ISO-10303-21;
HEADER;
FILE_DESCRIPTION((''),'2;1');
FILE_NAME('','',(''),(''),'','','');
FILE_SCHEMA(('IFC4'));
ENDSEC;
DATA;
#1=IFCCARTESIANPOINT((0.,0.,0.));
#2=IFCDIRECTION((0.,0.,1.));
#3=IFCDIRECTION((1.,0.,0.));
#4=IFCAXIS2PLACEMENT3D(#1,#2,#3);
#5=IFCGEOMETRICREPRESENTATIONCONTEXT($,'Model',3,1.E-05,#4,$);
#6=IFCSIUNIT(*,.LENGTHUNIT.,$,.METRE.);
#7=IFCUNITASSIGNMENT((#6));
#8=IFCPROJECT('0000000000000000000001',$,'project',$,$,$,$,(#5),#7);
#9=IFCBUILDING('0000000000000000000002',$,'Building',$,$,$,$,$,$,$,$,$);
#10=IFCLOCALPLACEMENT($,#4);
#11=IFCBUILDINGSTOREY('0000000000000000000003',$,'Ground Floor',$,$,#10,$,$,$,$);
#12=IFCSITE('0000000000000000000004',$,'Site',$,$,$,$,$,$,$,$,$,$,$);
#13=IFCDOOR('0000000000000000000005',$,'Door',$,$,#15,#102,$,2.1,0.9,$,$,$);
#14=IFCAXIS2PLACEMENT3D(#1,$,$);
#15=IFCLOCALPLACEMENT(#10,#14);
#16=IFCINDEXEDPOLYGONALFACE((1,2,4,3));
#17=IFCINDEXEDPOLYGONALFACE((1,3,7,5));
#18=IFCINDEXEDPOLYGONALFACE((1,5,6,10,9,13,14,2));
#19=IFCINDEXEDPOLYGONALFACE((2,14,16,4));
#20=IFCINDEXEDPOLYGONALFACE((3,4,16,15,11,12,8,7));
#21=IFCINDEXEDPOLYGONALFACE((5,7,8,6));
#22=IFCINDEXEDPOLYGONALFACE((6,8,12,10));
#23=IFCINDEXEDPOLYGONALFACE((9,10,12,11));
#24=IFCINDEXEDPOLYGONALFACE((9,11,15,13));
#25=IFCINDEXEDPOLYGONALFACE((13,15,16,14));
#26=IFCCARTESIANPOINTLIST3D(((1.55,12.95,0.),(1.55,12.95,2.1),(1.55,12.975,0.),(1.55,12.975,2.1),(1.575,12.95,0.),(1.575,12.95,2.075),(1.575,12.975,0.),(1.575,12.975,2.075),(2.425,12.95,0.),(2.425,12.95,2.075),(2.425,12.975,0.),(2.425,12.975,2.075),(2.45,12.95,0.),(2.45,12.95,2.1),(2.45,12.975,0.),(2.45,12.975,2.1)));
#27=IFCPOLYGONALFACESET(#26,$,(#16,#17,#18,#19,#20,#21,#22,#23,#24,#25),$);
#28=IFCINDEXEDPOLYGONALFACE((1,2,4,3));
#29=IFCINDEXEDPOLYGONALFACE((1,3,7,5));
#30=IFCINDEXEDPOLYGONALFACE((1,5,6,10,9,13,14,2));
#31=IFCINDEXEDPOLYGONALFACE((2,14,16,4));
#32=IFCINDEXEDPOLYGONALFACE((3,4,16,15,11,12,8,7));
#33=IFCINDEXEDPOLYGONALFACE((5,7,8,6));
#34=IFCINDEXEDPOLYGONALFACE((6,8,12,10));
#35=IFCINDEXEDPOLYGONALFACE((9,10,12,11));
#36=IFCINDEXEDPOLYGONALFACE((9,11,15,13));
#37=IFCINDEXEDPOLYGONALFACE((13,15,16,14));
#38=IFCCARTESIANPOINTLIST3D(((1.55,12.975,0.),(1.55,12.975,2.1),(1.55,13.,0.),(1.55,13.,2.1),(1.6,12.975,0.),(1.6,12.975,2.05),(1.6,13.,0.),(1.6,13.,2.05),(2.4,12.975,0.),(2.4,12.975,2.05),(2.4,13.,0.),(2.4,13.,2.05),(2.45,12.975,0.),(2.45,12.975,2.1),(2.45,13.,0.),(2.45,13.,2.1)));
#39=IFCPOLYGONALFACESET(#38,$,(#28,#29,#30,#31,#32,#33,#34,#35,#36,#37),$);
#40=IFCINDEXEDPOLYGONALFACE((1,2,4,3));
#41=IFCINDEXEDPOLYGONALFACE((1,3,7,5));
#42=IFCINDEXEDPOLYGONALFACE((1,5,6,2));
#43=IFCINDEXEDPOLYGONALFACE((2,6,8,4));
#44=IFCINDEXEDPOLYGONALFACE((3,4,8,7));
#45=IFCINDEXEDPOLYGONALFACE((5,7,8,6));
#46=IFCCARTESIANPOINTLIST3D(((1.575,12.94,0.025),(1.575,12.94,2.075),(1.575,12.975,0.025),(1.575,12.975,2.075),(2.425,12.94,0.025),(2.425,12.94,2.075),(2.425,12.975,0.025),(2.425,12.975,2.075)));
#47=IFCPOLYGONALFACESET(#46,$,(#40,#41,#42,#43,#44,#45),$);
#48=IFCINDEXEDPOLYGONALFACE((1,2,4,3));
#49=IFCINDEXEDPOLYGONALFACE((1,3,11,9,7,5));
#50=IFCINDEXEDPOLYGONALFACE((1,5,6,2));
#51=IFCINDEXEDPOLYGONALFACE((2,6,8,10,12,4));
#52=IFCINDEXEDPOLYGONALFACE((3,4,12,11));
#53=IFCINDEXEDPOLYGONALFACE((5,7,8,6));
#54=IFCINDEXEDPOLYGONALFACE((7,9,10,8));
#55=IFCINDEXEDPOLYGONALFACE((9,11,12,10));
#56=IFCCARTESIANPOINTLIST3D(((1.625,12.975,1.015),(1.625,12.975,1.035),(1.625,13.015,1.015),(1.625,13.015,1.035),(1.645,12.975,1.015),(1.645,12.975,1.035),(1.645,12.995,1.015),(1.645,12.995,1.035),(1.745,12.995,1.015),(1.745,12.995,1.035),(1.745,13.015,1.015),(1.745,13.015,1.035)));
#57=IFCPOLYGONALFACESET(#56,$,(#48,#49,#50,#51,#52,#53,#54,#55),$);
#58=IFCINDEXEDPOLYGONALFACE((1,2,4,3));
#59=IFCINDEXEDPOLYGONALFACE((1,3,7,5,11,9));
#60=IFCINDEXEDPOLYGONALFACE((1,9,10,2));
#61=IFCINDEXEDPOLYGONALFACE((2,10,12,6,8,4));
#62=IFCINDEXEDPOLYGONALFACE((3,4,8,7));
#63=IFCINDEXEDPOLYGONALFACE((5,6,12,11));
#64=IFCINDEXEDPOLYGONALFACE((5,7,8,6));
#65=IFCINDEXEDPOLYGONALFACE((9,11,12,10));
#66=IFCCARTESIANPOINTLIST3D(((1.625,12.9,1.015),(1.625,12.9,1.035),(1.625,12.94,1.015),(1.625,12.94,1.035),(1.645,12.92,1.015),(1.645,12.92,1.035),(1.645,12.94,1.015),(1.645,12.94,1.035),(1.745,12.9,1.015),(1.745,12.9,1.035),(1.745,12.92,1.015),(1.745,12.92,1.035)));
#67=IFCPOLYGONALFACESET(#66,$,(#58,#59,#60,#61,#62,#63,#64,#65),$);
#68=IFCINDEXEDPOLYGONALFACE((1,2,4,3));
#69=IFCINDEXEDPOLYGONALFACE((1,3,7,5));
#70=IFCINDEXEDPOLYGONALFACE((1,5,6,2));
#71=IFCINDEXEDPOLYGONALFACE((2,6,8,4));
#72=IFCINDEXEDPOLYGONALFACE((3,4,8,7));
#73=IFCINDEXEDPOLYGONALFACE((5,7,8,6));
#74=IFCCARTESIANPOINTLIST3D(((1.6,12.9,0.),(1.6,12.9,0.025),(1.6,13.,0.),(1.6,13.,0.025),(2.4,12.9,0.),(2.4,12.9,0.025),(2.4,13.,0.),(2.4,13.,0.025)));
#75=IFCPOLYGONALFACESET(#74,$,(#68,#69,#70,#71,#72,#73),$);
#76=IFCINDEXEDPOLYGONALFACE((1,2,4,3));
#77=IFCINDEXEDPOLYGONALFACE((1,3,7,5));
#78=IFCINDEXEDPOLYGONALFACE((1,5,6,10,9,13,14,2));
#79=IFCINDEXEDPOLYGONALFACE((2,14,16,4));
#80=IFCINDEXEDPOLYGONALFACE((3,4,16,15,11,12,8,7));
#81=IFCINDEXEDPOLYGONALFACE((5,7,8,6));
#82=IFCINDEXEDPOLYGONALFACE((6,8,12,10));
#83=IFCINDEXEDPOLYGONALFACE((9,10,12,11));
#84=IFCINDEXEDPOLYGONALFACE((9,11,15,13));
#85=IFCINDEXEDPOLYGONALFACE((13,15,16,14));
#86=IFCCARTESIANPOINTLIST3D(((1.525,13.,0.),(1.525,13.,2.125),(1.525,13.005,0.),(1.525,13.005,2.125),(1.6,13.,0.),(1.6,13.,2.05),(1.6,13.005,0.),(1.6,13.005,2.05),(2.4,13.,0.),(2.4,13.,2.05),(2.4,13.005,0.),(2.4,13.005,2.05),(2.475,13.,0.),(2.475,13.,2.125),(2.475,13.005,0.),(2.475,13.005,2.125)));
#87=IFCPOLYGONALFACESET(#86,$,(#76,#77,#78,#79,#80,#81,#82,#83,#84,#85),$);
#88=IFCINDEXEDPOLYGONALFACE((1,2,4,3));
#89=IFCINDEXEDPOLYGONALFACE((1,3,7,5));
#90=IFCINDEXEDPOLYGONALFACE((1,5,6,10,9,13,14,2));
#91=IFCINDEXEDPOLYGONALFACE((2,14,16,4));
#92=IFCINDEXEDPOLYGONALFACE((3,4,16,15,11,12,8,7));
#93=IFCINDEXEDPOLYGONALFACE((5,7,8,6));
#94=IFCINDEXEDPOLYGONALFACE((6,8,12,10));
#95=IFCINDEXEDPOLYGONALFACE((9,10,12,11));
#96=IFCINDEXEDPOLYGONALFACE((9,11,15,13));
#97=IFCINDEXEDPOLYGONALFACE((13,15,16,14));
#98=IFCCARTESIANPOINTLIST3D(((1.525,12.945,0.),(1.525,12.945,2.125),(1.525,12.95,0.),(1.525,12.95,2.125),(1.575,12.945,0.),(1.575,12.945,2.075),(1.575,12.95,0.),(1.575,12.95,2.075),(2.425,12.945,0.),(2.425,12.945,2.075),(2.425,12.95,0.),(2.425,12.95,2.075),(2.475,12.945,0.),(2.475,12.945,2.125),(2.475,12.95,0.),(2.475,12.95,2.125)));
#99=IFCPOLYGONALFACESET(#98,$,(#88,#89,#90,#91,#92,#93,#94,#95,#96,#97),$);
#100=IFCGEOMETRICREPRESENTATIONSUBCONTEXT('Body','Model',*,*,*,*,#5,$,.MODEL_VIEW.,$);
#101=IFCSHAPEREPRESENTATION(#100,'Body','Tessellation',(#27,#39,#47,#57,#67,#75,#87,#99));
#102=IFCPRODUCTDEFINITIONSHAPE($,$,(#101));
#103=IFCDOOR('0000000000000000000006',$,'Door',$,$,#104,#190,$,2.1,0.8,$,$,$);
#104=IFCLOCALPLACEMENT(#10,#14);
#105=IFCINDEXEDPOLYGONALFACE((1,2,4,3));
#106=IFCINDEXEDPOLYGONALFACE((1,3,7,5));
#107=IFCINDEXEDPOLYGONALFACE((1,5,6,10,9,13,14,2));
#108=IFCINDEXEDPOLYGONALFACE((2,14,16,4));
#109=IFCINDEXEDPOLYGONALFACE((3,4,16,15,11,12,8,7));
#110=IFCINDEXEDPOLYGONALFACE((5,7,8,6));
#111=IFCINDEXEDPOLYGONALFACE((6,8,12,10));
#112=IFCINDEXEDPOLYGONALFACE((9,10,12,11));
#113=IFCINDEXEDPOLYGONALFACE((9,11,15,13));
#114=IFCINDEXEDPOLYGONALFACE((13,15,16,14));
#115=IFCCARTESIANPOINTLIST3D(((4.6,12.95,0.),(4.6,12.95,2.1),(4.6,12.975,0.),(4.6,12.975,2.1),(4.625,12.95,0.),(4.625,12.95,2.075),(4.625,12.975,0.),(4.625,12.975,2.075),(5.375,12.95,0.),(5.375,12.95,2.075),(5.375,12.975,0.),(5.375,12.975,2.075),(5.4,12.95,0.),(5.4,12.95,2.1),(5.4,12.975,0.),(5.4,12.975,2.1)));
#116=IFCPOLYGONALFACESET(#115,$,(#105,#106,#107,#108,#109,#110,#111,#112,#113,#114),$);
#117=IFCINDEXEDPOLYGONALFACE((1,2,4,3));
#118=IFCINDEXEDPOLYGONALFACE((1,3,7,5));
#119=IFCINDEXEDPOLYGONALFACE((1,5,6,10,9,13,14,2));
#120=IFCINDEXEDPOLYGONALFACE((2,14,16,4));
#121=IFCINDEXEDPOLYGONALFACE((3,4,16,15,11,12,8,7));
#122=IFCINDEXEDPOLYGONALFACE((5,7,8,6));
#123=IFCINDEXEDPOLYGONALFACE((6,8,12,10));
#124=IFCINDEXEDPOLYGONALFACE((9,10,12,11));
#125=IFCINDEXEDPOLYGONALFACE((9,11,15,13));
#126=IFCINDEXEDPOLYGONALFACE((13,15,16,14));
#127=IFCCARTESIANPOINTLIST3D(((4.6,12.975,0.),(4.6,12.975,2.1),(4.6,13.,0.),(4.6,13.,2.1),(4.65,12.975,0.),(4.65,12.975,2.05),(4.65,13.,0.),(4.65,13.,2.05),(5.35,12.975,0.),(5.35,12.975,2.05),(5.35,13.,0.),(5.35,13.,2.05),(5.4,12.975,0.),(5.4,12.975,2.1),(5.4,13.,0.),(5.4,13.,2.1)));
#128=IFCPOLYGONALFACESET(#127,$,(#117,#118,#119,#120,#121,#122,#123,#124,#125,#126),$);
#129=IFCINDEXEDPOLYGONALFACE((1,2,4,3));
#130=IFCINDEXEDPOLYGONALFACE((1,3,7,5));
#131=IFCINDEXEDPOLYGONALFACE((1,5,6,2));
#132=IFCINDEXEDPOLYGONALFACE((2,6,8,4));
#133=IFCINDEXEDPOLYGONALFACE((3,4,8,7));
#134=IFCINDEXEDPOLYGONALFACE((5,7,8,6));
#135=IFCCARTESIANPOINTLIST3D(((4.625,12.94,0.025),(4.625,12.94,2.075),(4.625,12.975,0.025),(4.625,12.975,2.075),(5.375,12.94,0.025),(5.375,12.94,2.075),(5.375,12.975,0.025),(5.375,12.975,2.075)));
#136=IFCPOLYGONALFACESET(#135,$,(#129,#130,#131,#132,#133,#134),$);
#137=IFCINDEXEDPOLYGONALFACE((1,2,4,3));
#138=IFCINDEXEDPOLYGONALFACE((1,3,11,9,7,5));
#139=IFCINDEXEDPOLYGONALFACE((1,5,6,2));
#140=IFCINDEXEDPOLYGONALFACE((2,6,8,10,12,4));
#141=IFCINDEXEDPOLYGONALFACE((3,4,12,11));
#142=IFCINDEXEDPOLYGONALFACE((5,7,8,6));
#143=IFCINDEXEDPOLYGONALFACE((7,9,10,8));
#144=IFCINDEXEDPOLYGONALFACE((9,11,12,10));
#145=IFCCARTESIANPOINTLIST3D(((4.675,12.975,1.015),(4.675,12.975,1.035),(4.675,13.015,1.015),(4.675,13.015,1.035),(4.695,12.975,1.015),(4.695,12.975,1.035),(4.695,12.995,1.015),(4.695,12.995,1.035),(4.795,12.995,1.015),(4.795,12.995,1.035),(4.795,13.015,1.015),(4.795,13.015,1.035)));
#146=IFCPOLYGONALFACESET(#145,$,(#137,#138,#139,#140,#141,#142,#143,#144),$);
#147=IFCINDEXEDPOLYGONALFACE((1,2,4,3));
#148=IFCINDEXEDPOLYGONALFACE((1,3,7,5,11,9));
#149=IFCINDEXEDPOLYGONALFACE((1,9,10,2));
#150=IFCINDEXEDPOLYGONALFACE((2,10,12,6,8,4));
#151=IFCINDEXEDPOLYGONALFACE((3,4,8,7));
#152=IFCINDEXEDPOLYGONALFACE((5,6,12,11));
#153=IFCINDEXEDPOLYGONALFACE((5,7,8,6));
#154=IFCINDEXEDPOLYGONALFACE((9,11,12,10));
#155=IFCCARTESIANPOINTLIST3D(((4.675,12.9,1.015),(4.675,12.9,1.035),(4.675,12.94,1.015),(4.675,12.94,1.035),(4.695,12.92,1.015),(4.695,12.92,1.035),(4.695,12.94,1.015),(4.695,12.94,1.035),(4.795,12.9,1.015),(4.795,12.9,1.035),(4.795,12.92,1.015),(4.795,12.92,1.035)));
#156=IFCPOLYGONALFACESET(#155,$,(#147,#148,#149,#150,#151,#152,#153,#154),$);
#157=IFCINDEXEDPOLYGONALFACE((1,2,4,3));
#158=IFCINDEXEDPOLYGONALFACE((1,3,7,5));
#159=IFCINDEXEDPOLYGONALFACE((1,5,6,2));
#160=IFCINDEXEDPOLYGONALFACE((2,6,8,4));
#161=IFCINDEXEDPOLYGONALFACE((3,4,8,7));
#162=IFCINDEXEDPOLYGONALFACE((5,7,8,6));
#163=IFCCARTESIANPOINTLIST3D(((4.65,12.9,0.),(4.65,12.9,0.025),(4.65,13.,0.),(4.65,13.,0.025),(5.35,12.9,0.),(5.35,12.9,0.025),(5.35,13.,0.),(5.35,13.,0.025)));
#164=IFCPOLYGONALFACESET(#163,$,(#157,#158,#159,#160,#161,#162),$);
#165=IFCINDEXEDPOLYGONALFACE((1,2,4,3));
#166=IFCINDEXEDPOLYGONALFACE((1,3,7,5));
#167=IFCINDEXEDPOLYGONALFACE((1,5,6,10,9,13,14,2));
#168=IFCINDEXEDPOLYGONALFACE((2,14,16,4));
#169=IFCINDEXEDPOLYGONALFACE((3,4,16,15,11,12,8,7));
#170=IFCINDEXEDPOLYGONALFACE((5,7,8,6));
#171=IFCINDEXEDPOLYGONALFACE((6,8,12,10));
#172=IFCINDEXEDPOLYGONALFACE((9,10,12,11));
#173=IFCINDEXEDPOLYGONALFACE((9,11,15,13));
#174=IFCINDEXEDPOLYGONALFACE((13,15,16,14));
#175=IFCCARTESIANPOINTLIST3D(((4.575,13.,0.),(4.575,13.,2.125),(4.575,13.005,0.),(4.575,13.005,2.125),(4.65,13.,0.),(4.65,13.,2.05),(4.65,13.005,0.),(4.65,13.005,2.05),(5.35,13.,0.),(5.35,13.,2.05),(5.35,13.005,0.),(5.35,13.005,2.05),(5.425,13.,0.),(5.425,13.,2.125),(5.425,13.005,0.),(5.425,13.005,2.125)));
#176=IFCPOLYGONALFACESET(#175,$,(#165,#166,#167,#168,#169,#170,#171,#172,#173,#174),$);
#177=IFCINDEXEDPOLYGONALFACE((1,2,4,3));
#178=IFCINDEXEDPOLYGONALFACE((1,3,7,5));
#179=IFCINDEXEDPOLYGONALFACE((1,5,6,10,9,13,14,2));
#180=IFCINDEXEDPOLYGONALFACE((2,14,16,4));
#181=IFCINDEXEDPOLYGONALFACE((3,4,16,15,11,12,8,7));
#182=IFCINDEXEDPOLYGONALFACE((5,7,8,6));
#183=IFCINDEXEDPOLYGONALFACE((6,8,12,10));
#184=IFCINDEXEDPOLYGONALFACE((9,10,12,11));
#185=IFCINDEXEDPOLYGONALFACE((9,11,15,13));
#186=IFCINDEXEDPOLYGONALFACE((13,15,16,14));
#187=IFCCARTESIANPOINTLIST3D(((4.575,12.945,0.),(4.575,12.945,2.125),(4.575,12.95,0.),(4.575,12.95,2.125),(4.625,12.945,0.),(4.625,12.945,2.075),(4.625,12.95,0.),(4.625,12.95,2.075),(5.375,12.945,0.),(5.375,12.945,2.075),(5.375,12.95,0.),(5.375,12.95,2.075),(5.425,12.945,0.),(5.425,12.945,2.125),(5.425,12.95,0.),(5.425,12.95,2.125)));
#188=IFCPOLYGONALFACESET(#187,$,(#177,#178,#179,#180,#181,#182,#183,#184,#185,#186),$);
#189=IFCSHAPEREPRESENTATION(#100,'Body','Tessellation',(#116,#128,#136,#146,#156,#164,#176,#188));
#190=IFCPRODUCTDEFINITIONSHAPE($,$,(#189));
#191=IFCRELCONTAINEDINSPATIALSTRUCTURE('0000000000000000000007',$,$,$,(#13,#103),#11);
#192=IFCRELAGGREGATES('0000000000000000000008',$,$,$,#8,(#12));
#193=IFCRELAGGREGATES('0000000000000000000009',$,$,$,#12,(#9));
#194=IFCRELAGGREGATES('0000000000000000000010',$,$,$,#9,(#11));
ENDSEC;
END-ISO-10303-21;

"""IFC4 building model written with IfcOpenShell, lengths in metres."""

from ifc_helpers import new_model, si_unit, frame, origin_with_axes, place, context, subcontext, project, spatial, line, indexed_curve, outline, extrude, element, save


model = new_model("IFC4")

# Units and contexts
model_context = context("Model", 3, precision=1e-05, world=origin_with_axes())
body_context = subcontext(model_context, "Body", "Model", "MODEL_VIEW")
ifc_project = project(units=[si_unit("LENGTHUNIT", "METRE")], contexts=[model_context])

# Site, building, storey
site = spatial("IfcSite", under=ifc_project, Name="Site")
building = spatial("IfcBuilding", under=site, Name="Building")
storey_placement = place(None, origin_with_axes())
storey = spatial("IfcBuildingStorey", under=building, at=storey_placement, Name="Ground Floor")

# Doors
door_1_placement = place(storey_placement, frame((2.45, 13.0, 0.0), z_axis=(0.0, 0.0, 1.0), x_axis=(-1.0, 0.0, 0.0)))
element("IfcDoor", 1, at=door_1_placement, inside=storey, Name="Door", OverallHeight=2.1, OverallWidth=0.9, context=body_context, shape_type="SweptSolid", body=[
    extrude(outline(indexed_curve([(0.0, 0.0), (0.0, 2.1), (0.9, 2.1), (0.9, 0.0), (0.875, 0.0), (0.875, 2.075), (0.025, 2.075), (0.025, 0.0)], segments=[line(1, 2, 3, 4, 5, 6, 7, 8, 1)])), frame((0.0, 0.025, 0.0), z_axis=(0.0, -1.0, 0.0), x_axis=(1.0, 0.0, 0.0)), (0.0, 0.0, -1.0), 0.025),
    extrude(outline(indexed_curve([(0.0, 0.0), (0.0, 2.1), (0.9, 2.1), (0.9, 0.0), (0.85, 0.0), (0.85, 2.05), (0.05, 2.05), (0.05, 0.0)], segments=[line(1, 2, 3, 4, 5, 6, 7, 8, 1)])), frame((0.0, 0.0, 0.0), z_axis=(0.0, -1.0, 0.0), x_axis=(1.0, 0.0, 0.0)), (0.0, 0.0, -1.0), 0.025),
    extrude(outline(indexed_curve([(0.0, 0.0), (0.85, 0.0), (0.85, 0.035), (0.0, 0.035)], segments=[line(1, 2, 3, 4, 1)])), frame((0.025, 0.025, 0.025), z_axis=(0.0, 0.0, 1.0), x_axis=(1.0, 0.0, 0.0)), (0.0, 0.0, 1.0), 2.05),
    extrude(outline(indexed_curve([(0.0, 0.0), (0.0, -0.04), (-0.12, -0.04), (-0.12, -0.02), (-0.02, -0.02), (-0.02, 0.0)], segments=[line(1, 2, 3, 4, 5, 6, 1)])), frame((0.825, 0.025, 1.015), z_axis=(0.0, 0.0, 1.0), x_axis=(1.0, 0.0, 0.0)), (0.0, 0.0, 1.0), 0.02),
    extrude(outline(indexed_curve([(0.0, 0.0), (0.0, 0.04), (-0.12, 0.04), (-0.12, 0.02), (-0.02, 0.02), (-0.02, 0.0)], segments=[line(1, 2, 3, 4, 5, 6, 1)])), frame((0.825, 0.06, 1.015), z_axis=(0.0, 0.0, 1.0), x_axis=(1.0, 0.0, 0.0)), (0.0, 0.0, 1.0), 0.02),
    extrude(outline(indexed_curve([(0.0, 0.0), (0.8, 0.0), (0.8, 0.1), (0.0, 0.1)], segments=[line(1, 2, 3, 4, 1)])), frame((0.05, 0.0, 0.0), z_axis=(0.0, 0.0, 1.0), x_axis=(1.0, 0.0, 0.0)), (0.0, 0.0, 1.0), 0.025),
    extrude(outline(indexed_curve([(0.0, 0.0), (0.0, 2.125), (0.95, 2.125), (0.95, 0.0), (0.875, 0.0), (0.875, 2.05), (0.075, 2.05), (0.075, 0.0)], segments=[line(1, 2, 3, 4, 5, 6, 7, 8, 1)])), frame((-0.025, -0.005, 0.0), z_axis=(0.0, -1.0, 0.0), x_axis=(1.0, 0.0, 0.0)), (0.0, 0.0, -1.0), 0.005),
    extrude(outline(indexed_curve([(0.0, 0.0), (0.0, 2.125), (0.95, 2.125), (0.95, 0.0), (0.9, 0.0), (0.9, 2.075), (0.05, 2.075), (0.05, 0.0)], segments=[line(1, 2, 3, 4, 5, 6, 7, 8, 1)])), frame((-0.025, 0.05, 0.0), z_axis=(0.0, -1.0, 0.0), x_axis=(1.0, 0.0, 0.0)), (0.0, 0.0, -1.0), 0.005),
])
door_2_placement = place(storey_placement, frame((5.4, 13.0, 0.0), z_axis=(0.0, 0.0, 1.0), x_axis=(-1.0, 0.0, 0.0)))
element("IfcDoor", 2, at=door_2_placement, inside=storey, Name="Door", OverallHeight=2.1, OverallWidth=0.8, context=body_context, shape_type="SweptSolid", body=[
    extrude(outline(indexed_curve([(0.0, 0.0), (0.0, 2.1), (0.8, 2.1), (0.8, 0.0), (0.775, 0.0), (0.775, 2.075), (0.025, 2.075), (0.025, 0.0)], segments=[line(1, 2, 3, 4, 5, 6, 7, 8, 1)])), frame((0.0, 0.025, 0.0), z_axis=(0.0, -1.0, 0.0), x_axis=(1.0, 0.0, 0.0)), (0.0, 0.0, -1.0), 0.025),
    extrude(outline(indexed_curve([(0.0, 0.0), (0.0, 2.1), (0.8, 2.1), (0.8, 0.0), (0.75, 0.0), (0.75, 2.05), (0.05, 2.05), (0.05, 0.0)], segments=[line(1, 2, 3, 4, 5, 6, 7, 8, 1)])), frame((0.0, 0.0, 0.0), z_axis=(0.0, -1.0, 0.0), x_axis=(1.0, 0.0, 0.0)), (0.0, 0.0, -1.0), 0.025),
    extrude(outline(indexed_curve([(0.0, 0.0), (0.75, 0.0), (0.75, 0.035), (0.0, 0.035)], segments=[line(1, 2, 3, 4, 1)])), frame((0.025, 0.025, 0.025), z_axis=(0.0, 0.0, 1.0), x_axis=(1.0, 0.0, 0.0)), (0.0, 0.0, 1.0), 2.05),
    extrude(outline(indexed_curve([(0.0, 0.0), (0.0, -0.04), (-0.12, -0.04), (-0.12, -0.02), (-0.02, -0.02), (-0.02, 0.0)], segments=[line(1, 2, 3, 4, 5, 6, 1)])), frame((0.725, 0.025, 1.015), z_axis=(0.0, 0.0, 1.0), x_axis=(1.0, 0.0, 0.0)), (0.0, 0.0, 1.0), 0.02),
    extrude(outline(indexed_curve([(0.0, 0.0), (0.0, 0.04), (-0.12, 0.04), (-0.12, 0.02), (-0.02, 0.02), (-0.02, 0.0)], segments=[line(1, 2, 3, 4, 5, 6, 1)])), frame((0.725, 0.06, 1.015), z_axis=(0.0, 0.0, 1.0), x_axis=(1.0, 0.0, 0.0)), (0.0, 0.0, 1.0), 0.02),
    extrude(outline(indexed_curve([(0.0, 0.0), (0.7, 0.0), (0.7, 0.1), (0.0, 0.1)], segments=[line(1, 2, 3, 4, 1)])), frame((0.05, 0.0, 0.0), z_axis=(0.0, 0.0, 1.0), x_axis=(1.0, 0.0, 0.0)), (0.0, 0.0, 1.0), 0.025),
    extrude(outline(indexed_curve([(0.0, 0.0), (0.0, 2.125), (0.85, 2.125), (0.85, 0.0), (0.775, 0.0), (0.775, 2.05), (0.075, 2.05), (0.075, 0.0)], segments=[line(1, 2, 3, 4, 5, 6, 7, 8, 1)])), frame((-0.025, -0.005, 0.0), z_axis=(0.0, -1.0, 0.0), x_axis=(1.0, 0.0, 0.0)), (0.0, 0.0, -1.0), 0.005),
    extrude(outline(indexed_curve([(0.0, 0.0), (0.0, 2.125), (0.85, 2.125), (0.85, 0.0), (0.8, 0.0), (0.8, 2.075), (0.05, 2.075), (0.05, 0.0)], segments=[line(1, 2, 3, 4, 5, 6, 7, 8, 1)])), frame((-0.025, 0.05, 0.0), z_axis=(0.0, -1.0, 0.0), x_axis=(1.0, 0.0, 0.0)), (0.0, 0.0, -1.0), 0.005),
])

save(model, "model.ifc")
